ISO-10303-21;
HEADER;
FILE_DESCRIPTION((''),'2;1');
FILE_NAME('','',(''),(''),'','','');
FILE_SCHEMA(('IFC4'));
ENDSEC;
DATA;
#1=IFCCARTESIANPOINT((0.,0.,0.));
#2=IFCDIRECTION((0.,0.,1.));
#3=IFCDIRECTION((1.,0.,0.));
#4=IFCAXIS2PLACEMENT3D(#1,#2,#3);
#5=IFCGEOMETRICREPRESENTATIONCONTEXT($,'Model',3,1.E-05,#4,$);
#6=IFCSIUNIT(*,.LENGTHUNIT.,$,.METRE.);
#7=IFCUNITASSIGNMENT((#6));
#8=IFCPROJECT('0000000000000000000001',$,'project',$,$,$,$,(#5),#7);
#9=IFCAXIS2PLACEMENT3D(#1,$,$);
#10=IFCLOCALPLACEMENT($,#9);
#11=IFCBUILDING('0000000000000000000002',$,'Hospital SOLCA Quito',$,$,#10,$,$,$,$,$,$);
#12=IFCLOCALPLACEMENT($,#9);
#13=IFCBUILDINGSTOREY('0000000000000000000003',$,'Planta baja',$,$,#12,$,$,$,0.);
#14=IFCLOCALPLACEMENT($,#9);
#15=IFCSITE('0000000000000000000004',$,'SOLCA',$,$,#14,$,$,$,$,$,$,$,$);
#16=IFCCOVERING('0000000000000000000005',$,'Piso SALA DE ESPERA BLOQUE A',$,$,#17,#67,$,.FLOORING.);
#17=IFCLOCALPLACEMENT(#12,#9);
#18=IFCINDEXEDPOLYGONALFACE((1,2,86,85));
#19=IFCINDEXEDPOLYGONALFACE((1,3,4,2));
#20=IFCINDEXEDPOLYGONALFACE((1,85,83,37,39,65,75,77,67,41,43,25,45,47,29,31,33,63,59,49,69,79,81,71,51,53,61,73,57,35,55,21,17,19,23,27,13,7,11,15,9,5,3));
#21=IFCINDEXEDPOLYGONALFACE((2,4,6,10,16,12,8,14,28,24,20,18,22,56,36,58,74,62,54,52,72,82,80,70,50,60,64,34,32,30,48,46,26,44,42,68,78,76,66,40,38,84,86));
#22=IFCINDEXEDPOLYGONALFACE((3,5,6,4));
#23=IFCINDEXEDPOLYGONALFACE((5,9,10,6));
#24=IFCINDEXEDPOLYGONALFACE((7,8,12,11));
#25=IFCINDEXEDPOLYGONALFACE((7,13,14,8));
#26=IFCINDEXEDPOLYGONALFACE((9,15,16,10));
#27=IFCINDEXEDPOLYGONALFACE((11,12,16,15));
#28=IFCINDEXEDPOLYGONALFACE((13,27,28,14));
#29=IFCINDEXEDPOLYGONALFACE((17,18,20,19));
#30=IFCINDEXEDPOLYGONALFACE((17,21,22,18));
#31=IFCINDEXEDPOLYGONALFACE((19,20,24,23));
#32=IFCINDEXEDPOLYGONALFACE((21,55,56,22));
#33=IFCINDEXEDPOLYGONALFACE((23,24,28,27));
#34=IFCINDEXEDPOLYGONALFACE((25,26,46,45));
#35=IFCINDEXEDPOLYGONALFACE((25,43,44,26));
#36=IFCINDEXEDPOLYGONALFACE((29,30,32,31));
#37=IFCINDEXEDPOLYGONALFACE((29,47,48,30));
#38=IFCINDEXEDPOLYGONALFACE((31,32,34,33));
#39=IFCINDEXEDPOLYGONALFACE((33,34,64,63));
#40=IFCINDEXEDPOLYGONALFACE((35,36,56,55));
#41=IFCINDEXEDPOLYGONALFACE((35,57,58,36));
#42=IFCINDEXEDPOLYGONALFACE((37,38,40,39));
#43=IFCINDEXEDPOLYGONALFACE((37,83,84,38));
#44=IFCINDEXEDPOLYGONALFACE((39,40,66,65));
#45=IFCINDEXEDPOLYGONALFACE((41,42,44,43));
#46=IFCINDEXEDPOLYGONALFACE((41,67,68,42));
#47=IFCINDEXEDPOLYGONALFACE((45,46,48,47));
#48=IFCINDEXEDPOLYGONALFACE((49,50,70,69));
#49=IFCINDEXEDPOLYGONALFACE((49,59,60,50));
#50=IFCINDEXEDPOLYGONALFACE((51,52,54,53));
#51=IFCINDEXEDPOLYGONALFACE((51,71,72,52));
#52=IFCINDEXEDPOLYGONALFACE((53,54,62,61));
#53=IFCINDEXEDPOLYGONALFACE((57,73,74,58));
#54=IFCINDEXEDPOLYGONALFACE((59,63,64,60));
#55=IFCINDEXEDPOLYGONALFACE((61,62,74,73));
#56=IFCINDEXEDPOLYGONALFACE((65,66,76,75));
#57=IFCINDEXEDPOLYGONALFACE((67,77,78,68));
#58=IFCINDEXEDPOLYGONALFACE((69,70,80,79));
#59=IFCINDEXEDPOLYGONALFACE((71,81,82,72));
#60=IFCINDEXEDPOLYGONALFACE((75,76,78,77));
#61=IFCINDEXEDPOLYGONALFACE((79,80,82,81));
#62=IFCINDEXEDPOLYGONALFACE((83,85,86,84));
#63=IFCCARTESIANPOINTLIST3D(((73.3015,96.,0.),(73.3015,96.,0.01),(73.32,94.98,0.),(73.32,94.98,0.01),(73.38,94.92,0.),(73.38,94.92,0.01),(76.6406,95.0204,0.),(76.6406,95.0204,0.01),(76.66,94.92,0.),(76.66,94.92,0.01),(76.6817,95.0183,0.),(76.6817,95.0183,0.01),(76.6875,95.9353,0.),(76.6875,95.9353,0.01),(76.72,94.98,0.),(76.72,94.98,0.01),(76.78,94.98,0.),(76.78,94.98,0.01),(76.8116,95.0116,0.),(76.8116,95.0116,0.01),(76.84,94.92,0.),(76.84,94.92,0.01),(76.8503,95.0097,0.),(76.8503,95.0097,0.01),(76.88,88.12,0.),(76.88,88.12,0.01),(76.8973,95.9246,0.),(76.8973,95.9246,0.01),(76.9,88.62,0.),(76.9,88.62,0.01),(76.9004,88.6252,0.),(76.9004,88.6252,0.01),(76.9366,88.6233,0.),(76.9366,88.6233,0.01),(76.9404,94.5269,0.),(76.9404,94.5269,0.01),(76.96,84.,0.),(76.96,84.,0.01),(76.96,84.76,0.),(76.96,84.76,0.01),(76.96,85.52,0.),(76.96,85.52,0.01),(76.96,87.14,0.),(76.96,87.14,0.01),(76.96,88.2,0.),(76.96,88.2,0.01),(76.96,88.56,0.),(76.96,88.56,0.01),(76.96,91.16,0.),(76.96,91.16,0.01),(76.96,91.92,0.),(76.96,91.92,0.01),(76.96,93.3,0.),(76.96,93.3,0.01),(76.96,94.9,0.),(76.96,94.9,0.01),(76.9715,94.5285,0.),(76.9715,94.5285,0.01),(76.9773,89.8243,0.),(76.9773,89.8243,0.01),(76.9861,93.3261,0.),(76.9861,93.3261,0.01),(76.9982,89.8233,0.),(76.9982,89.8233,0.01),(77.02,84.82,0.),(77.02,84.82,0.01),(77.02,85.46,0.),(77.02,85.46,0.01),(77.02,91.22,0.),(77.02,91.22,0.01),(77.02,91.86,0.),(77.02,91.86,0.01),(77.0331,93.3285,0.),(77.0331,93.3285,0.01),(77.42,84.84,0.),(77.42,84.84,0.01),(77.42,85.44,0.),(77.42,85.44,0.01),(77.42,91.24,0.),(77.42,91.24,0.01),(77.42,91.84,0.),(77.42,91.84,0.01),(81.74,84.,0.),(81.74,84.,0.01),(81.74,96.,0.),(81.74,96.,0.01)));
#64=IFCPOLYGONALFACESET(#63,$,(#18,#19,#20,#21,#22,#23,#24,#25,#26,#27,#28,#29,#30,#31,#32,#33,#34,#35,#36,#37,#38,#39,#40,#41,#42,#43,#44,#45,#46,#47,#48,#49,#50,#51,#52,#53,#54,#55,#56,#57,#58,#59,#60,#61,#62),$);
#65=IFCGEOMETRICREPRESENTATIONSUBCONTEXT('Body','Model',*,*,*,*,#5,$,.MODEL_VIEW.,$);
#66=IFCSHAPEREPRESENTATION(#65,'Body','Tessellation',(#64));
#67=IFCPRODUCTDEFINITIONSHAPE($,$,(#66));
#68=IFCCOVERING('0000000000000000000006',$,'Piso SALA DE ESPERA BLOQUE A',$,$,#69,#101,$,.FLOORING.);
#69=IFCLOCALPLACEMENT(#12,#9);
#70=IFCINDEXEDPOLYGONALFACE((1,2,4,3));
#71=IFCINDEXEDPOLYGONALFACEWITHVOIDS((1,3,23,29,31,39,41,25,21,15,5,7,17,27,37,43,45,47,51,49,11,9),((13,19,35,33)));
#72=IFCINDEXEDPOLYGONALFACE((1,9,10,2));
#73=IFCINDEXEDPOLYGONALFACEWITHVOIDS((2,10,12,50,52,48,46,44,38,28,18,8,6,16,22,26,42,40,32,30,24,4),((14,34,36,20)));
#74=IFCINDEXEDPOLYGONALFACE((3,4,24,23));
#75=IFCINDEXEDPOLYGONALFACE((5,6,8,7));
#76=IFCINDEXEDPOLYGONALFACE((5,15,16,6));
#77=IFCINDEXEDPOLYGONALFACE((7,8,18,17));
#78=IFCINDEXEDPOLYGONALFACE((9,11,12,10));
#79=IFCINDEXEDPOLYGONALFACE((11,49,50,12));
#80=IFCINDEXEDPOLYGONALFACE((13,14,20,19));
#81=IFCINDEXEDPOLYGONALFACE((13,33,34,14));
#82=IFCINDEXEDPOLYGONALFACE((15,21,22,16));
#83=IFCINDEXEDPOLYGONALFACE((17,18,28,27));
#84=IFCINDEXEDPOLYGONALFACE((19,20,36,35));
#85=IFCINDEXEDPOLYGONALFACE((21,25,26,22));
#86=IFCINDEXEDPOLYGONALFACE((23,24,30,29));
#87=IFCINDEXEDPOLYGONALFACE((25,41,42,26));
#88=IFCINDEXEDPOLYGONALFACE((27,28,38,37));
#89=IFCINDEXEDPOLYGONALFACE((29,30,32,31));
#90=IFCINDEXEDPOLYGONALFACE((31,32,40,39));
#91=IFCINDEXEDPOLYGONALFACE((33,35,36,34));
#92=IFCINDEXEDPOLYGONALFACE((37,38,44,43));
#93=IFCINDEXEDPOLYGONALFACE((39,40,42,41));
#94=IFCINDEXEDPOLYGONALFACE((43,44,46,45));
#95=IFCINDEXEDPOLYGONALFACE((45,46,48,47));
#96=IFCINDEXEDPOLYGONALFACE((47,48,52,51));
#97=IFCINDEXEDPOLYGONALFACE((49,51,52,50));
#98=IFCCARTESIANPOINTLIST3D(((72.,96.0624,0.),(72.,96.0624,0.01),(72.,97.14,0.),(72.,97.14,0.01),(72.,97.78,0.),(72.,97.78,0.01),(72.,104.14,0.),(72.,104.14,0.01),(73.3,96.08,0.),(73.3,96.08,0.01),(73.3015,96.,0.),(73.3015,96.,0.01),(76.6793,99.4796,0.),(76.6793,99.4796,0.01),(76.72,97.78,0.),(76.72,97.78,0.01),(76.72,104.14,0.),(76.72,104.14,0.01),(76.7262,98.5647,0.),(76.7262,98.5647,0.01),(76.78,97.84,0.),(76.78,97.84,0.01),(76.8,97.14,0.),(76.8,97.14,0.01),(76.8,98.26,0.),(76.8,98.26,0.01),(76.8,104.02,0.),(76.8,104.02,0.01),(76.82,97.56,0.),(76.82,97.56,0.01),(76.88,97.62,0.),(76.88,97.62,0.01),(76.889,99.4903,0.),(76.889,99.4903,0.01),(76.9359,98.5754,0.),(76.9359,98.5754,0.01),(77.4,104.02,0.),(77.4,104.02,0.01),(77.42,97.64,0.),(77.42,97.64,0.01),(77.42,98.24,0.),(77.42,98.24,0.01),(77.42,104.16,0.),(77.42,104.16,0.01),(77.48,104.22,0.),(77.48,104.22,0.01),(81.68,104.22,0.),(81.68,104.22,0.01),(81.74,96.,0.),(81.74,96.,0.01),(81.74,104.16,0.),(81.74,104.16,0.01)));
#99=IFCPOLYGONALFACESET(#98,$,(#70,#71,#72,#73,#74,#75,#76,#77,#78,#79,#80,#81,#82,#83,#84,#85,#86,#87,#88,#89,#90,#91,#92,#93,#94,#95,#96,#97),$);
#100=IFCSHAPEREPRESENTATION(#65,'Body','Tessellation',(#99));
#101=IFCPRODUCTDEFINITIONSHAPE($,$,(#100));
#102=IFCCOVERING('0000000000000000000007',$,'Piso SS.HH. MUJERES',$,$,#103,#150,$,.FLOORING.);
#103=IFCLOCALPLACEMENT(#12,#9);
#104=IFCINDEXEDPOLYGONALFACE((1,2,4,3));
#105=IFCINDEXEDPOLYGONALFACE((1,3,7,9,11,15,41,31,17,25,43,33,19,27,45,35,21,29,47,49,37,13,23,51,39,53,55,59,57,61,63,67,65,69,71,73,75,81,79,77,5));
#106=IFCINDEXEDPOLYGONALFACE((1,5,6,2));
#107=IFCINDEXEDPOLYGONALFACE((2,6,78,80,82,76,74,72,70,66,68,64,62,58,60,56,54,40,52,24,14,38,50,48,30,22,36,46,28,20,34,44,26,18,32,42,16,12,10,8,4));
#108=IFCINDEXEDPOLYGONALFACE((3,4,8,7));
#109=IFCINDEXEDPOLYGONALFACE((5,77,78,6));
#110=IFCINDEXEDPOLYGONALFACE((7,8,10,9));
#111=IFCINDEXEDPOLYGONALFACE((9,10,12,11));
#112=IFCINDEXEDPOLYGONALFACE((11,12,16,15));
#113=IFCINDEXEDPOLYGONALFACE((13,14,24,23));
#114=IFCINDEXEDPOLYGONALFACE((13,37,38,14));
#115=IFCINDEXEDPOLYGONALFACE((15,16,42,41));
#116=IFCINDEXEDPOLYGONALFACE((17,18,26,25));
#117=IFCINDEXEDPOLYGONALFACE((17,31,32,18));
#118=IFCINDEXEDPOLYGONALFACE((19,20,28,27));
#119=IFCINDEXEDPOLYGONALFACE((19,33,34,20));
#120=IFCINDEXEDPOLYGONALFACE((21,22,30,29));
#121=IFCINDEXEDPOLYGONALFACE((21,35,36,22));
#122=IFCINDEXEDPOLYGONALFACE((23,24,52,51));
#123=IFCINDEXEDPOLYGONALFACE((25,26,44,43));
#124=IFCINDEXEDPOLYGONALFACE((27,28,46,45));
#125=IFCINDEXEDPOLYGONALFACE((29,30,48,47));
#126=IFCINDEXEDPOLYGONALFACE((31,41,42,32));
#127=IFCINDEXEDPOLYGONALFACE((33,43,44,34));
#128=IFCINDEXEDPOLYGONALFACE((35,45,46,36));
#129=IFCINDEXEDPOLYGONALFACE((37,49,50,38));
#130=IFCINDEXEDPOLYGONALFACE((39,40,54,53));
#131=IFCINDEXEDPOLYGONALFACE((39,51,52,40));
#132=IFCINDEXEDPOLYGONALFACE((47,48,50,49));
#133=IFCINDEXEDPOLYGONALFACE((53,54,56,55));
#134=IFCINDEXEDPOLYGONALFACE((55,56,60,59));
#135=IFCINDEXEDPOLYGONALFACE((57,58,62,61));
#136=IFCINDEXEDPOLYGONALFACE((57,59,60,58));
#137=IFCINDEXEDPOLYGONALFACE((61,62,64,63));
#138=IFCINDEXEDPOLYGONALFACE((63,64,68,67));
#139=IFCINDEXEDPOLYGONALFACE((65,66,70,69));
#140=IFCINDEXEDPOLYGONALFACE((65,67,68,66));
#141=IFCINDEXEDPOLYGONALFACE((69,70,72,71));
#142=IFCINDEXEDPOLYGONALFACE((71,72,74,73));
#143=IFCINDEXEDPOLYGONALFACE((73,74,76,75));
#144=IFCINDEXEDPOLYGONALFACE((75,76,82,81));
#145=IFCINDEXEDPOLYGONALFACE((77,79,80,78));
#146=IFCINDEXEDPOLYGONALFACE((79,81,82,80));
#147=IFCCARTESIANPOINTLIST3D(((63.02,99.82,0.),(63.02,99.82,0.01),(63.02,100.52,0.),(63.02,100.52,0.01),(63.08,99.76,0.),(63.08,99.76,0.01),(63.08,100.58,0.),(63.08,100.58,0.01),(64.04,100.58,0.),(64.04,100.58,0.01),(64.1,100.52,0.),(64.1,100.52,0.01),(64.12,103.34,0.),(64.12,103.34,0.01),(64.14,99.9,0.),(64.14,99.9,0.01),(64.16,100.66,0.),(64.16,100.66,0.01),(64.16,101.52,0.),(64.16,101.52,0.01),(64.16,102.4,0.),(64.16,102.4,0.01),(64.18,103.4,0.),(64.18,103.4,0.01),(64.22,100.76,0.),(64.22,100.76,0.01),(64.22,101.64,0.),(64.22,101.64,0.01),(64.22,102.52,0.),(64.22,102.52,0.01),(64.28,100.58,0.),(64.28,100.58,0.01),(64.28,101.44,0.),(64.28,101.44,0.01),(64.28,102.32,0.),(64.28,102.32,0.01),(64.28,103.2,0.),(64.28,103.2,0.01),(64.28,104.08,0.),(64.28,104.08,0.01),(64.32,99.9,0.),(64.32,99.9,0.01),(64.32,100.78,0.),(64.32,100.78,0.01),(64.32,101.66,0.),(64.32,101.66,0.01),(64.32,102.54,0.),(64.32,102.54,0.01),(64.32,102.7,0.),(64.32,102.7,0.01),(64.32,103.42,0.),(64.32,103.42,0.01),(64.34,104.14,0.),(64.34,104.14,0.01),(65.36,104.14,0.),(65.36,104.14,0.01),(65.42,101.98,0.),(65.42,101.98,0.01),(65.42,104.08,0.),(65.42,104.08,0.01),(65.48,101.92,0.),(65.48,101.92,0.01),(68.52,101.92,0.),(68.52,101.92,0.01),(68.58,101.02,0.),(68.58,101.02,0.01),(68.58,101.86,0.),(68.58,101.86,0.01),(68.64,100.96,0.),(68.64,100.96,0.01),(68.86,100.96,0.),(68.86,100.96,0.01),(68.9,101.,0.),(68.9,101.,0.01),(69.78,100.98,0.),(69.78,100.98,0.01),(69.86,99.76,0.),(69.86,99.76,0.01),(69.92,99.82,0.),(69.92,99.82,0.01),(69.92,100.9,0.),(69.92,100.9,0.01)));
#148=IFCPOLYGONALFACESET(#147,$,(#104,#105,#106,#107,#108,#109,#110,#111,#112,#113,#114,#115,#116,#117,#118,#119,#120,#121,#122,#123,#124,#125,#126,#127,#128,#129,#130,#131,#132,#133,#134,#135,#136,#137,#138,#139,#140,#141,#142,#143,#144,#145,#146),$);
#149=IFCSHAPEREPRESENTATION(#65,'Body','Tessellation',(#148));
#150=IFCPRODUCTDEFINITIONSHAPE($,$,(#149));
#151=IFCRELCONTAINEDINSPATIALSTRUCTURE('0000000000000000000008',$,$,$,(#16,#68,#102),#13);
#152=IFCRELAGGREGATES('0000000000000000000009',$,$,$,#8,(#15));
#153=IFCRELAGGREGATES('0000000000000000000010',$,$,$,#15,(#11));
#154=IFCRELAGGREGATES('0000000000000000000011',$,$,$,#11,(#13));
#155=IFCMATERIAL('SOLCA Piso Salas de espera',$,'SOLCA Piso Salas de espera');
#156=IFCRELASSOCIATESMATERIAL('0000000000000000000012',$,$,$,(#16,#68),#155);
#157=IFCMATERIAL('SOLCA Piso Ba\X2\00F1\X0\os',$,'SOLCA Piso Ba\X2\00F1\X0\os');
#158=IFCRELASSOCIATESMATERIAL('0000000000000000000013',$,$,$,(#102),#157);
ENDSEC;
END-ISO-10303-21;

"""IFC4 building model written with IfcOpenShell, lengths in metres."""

from ifc_helpers import new_model, si_unit, origin, origin_with_axes, place, context, subcontext, project, spatial, polyline, outline, extrude, material, element, save


model = new_model("IFC4")

# Units and contexts
model_context = context("Model", 3, precision=1e-05, world=origin_with_axes())
body_context = subcontext(model_context, "Body", "Model", "MODEL_VIEW")
ifc_project = project(units=[si_unit("LENGTHUNIT", "METRE")], contexts=[model_context])

# Site, building, storey
site_placement = place(None, origin())
site = spatial("IfcSite", under=ifc_project, at=site_placement, Name="SOLCA")
building_placement = place(None, origin())
building = spatial("IfcBuilding", under=site, at=building_placement, Name="Hospital SOLCA Quito")
storey_placement = place(None, origin())
storey = spatial("IfcBuildingStorey", under=building, at=storey_placement, Name="Planta baja", Elevation=0.0)

# Coverings
ifc_material_1 = material(Name="SOLCA Piso Salas de espera", Category="SOLCA Piso Salas de espera")
covering_1_placement = place(storey_placement, origin_with_axes())
element("IfcCovering", 1, at=covering_1_placement, inside=storey, material=ifc_material_1, Name="Piso SALA DE ESPERA BLOQUE A", PredefinedType="FLOORING", context=body_context, shape_type="SweptSolid", body=[
    extrude(outline(polyline([(76.96, 84.76), (77.02, 84.82), (77.42, 84.84), (77.42, 85.44), (77.02, 85.46), (76.96, 85.52), (76.96, 87.14), (76.88, 88.12), (76.96, 88.2), (76.96, 88.56), (76.9, 88.62), (76.9004, 88.6252), (76.9366, 88.6233), (76.9982, 89.8233), (76.9773, 89.8243), (76.96, 91.16), (77.02, 91.22), (77.42, 91.24), (77.42, 91.84), (77.02, 91.86), (76.96, 91.92), (76.96, 93.3), (76.9861, 93.3261), (77.0331, 93.3285), (76.9715, 94.5285), (76.9404, 94.5269), (76.96, 94.9), (76.84, 94.92), (76.78, 94.98), (76.8116, 95.0116), (76.8503, 95.0097), (76.8973, 95.9246), (76.6875, 95.9353), (76.6406, 95.0204), (76.6817, 95.0183), (76.72, 94.98), (76.66, 94.92), (73.38, 94.92), (73.32, 94.98), (73.3015, 96.0), (81.74, 96.0), (81.74, 84.0), (76.96, 84.0), (76.96, 84.76)])), origin_with_axes(), (0.0, 0.0, 1.0), 0.01),
])
covering_2_placement = place(storey_placement, origin_with_axes())
element("IfcCovering", 2, at=covering_2_placement, inside=storey, material=ifc_material_1, Name="Piso SALA DE ESPERA BLOQUE A", PredefinedType="FLOORING", context=body_context, shape_type="SweptSolid", body=[
    extrude(outline(polyline([(73.3, 96.08), (72.0, 96.0624), (72.0, 97.14), (76.8, 97.14), (76.82, 97.56), (76.88, 97.62), (77.42, 97.64), (77.42, 98.24), (76.8, 98.26), (76.78, 97.84), (76.72, 97.78), (72.0, 97.78), (72.0, 104.14), (76.72, 104.14), (76.8, 104.02), (77.4, 104.02), (77.42, 104.16), (77.48, 104.22), (81.68, 104.22), (81.74, 104.16), (81.74, 96.0), (73.3015, 96.0), (73.3, 96.08)]), holes=[polyline([(76.889, 99.4903), (76.6793, 99.4796), (76.7262, 98.5647), (76.9359, 98.5754), (76.889, 99.4903)])]), origin_with_axes(), (0.0, 0.0, 1.0), 0.01),
])
ifc_material_2 = material(Name="SOLCA Piso Baños", Category="SOLCA Piso Baños")
covering_3_placement = place(storey_placement, origin_with_axes())
element("IfcCovering", 3, at=covering_3_placement, inside=storey, material=ifc_material_2, Name="Piso SS.HH. MUJERES", PredefinedType="FLOORING", context=body_context, shape_type="SweptSolid", body=[
    extrude(outline(polyline([(65.36, 104.14), (65.42, 104.08), (65.42, 101.98), (65.48, 101.92), (68.52, 101.92), (68.58, 101.86), (68.58, 101.02), (68.64, 100.96), (68.86, 100.96), (68.9, 101.0), (69.78, 100.98), (69.92, 100.9), (69.92, 99.82), (69.86, 99.76), (63.08, 99.76), (63.02, 99.82), (63.02, 100.52), (63.08, 100.58), (64.04, 100.58), (64.1, 100.52), (64.14, 99.9), (64.32, 99.9), (64.28, 100.58), (64.16, 100.66), (64.22, 100.76), (64.32, 100.78), (64.28, 101.44), (64.16, 101.52), (64.22, 101.64), (64.32, 101.66), (64.28, 102.32), (64.16, 102.4), (64.22, 102.52), (64.32, 102.54), (64.32, 102.7), (64.28, 103.2), (64.12, 103.34), (64.18, 103.4), (64.32, 103.42), (64.28, 104.08), (64.34, 104.14), (65.36, 104.14)])), origin_with_axes(), (0.0, 0.0, 1.0), 0.01),
])

save(model, "model.ifc")
